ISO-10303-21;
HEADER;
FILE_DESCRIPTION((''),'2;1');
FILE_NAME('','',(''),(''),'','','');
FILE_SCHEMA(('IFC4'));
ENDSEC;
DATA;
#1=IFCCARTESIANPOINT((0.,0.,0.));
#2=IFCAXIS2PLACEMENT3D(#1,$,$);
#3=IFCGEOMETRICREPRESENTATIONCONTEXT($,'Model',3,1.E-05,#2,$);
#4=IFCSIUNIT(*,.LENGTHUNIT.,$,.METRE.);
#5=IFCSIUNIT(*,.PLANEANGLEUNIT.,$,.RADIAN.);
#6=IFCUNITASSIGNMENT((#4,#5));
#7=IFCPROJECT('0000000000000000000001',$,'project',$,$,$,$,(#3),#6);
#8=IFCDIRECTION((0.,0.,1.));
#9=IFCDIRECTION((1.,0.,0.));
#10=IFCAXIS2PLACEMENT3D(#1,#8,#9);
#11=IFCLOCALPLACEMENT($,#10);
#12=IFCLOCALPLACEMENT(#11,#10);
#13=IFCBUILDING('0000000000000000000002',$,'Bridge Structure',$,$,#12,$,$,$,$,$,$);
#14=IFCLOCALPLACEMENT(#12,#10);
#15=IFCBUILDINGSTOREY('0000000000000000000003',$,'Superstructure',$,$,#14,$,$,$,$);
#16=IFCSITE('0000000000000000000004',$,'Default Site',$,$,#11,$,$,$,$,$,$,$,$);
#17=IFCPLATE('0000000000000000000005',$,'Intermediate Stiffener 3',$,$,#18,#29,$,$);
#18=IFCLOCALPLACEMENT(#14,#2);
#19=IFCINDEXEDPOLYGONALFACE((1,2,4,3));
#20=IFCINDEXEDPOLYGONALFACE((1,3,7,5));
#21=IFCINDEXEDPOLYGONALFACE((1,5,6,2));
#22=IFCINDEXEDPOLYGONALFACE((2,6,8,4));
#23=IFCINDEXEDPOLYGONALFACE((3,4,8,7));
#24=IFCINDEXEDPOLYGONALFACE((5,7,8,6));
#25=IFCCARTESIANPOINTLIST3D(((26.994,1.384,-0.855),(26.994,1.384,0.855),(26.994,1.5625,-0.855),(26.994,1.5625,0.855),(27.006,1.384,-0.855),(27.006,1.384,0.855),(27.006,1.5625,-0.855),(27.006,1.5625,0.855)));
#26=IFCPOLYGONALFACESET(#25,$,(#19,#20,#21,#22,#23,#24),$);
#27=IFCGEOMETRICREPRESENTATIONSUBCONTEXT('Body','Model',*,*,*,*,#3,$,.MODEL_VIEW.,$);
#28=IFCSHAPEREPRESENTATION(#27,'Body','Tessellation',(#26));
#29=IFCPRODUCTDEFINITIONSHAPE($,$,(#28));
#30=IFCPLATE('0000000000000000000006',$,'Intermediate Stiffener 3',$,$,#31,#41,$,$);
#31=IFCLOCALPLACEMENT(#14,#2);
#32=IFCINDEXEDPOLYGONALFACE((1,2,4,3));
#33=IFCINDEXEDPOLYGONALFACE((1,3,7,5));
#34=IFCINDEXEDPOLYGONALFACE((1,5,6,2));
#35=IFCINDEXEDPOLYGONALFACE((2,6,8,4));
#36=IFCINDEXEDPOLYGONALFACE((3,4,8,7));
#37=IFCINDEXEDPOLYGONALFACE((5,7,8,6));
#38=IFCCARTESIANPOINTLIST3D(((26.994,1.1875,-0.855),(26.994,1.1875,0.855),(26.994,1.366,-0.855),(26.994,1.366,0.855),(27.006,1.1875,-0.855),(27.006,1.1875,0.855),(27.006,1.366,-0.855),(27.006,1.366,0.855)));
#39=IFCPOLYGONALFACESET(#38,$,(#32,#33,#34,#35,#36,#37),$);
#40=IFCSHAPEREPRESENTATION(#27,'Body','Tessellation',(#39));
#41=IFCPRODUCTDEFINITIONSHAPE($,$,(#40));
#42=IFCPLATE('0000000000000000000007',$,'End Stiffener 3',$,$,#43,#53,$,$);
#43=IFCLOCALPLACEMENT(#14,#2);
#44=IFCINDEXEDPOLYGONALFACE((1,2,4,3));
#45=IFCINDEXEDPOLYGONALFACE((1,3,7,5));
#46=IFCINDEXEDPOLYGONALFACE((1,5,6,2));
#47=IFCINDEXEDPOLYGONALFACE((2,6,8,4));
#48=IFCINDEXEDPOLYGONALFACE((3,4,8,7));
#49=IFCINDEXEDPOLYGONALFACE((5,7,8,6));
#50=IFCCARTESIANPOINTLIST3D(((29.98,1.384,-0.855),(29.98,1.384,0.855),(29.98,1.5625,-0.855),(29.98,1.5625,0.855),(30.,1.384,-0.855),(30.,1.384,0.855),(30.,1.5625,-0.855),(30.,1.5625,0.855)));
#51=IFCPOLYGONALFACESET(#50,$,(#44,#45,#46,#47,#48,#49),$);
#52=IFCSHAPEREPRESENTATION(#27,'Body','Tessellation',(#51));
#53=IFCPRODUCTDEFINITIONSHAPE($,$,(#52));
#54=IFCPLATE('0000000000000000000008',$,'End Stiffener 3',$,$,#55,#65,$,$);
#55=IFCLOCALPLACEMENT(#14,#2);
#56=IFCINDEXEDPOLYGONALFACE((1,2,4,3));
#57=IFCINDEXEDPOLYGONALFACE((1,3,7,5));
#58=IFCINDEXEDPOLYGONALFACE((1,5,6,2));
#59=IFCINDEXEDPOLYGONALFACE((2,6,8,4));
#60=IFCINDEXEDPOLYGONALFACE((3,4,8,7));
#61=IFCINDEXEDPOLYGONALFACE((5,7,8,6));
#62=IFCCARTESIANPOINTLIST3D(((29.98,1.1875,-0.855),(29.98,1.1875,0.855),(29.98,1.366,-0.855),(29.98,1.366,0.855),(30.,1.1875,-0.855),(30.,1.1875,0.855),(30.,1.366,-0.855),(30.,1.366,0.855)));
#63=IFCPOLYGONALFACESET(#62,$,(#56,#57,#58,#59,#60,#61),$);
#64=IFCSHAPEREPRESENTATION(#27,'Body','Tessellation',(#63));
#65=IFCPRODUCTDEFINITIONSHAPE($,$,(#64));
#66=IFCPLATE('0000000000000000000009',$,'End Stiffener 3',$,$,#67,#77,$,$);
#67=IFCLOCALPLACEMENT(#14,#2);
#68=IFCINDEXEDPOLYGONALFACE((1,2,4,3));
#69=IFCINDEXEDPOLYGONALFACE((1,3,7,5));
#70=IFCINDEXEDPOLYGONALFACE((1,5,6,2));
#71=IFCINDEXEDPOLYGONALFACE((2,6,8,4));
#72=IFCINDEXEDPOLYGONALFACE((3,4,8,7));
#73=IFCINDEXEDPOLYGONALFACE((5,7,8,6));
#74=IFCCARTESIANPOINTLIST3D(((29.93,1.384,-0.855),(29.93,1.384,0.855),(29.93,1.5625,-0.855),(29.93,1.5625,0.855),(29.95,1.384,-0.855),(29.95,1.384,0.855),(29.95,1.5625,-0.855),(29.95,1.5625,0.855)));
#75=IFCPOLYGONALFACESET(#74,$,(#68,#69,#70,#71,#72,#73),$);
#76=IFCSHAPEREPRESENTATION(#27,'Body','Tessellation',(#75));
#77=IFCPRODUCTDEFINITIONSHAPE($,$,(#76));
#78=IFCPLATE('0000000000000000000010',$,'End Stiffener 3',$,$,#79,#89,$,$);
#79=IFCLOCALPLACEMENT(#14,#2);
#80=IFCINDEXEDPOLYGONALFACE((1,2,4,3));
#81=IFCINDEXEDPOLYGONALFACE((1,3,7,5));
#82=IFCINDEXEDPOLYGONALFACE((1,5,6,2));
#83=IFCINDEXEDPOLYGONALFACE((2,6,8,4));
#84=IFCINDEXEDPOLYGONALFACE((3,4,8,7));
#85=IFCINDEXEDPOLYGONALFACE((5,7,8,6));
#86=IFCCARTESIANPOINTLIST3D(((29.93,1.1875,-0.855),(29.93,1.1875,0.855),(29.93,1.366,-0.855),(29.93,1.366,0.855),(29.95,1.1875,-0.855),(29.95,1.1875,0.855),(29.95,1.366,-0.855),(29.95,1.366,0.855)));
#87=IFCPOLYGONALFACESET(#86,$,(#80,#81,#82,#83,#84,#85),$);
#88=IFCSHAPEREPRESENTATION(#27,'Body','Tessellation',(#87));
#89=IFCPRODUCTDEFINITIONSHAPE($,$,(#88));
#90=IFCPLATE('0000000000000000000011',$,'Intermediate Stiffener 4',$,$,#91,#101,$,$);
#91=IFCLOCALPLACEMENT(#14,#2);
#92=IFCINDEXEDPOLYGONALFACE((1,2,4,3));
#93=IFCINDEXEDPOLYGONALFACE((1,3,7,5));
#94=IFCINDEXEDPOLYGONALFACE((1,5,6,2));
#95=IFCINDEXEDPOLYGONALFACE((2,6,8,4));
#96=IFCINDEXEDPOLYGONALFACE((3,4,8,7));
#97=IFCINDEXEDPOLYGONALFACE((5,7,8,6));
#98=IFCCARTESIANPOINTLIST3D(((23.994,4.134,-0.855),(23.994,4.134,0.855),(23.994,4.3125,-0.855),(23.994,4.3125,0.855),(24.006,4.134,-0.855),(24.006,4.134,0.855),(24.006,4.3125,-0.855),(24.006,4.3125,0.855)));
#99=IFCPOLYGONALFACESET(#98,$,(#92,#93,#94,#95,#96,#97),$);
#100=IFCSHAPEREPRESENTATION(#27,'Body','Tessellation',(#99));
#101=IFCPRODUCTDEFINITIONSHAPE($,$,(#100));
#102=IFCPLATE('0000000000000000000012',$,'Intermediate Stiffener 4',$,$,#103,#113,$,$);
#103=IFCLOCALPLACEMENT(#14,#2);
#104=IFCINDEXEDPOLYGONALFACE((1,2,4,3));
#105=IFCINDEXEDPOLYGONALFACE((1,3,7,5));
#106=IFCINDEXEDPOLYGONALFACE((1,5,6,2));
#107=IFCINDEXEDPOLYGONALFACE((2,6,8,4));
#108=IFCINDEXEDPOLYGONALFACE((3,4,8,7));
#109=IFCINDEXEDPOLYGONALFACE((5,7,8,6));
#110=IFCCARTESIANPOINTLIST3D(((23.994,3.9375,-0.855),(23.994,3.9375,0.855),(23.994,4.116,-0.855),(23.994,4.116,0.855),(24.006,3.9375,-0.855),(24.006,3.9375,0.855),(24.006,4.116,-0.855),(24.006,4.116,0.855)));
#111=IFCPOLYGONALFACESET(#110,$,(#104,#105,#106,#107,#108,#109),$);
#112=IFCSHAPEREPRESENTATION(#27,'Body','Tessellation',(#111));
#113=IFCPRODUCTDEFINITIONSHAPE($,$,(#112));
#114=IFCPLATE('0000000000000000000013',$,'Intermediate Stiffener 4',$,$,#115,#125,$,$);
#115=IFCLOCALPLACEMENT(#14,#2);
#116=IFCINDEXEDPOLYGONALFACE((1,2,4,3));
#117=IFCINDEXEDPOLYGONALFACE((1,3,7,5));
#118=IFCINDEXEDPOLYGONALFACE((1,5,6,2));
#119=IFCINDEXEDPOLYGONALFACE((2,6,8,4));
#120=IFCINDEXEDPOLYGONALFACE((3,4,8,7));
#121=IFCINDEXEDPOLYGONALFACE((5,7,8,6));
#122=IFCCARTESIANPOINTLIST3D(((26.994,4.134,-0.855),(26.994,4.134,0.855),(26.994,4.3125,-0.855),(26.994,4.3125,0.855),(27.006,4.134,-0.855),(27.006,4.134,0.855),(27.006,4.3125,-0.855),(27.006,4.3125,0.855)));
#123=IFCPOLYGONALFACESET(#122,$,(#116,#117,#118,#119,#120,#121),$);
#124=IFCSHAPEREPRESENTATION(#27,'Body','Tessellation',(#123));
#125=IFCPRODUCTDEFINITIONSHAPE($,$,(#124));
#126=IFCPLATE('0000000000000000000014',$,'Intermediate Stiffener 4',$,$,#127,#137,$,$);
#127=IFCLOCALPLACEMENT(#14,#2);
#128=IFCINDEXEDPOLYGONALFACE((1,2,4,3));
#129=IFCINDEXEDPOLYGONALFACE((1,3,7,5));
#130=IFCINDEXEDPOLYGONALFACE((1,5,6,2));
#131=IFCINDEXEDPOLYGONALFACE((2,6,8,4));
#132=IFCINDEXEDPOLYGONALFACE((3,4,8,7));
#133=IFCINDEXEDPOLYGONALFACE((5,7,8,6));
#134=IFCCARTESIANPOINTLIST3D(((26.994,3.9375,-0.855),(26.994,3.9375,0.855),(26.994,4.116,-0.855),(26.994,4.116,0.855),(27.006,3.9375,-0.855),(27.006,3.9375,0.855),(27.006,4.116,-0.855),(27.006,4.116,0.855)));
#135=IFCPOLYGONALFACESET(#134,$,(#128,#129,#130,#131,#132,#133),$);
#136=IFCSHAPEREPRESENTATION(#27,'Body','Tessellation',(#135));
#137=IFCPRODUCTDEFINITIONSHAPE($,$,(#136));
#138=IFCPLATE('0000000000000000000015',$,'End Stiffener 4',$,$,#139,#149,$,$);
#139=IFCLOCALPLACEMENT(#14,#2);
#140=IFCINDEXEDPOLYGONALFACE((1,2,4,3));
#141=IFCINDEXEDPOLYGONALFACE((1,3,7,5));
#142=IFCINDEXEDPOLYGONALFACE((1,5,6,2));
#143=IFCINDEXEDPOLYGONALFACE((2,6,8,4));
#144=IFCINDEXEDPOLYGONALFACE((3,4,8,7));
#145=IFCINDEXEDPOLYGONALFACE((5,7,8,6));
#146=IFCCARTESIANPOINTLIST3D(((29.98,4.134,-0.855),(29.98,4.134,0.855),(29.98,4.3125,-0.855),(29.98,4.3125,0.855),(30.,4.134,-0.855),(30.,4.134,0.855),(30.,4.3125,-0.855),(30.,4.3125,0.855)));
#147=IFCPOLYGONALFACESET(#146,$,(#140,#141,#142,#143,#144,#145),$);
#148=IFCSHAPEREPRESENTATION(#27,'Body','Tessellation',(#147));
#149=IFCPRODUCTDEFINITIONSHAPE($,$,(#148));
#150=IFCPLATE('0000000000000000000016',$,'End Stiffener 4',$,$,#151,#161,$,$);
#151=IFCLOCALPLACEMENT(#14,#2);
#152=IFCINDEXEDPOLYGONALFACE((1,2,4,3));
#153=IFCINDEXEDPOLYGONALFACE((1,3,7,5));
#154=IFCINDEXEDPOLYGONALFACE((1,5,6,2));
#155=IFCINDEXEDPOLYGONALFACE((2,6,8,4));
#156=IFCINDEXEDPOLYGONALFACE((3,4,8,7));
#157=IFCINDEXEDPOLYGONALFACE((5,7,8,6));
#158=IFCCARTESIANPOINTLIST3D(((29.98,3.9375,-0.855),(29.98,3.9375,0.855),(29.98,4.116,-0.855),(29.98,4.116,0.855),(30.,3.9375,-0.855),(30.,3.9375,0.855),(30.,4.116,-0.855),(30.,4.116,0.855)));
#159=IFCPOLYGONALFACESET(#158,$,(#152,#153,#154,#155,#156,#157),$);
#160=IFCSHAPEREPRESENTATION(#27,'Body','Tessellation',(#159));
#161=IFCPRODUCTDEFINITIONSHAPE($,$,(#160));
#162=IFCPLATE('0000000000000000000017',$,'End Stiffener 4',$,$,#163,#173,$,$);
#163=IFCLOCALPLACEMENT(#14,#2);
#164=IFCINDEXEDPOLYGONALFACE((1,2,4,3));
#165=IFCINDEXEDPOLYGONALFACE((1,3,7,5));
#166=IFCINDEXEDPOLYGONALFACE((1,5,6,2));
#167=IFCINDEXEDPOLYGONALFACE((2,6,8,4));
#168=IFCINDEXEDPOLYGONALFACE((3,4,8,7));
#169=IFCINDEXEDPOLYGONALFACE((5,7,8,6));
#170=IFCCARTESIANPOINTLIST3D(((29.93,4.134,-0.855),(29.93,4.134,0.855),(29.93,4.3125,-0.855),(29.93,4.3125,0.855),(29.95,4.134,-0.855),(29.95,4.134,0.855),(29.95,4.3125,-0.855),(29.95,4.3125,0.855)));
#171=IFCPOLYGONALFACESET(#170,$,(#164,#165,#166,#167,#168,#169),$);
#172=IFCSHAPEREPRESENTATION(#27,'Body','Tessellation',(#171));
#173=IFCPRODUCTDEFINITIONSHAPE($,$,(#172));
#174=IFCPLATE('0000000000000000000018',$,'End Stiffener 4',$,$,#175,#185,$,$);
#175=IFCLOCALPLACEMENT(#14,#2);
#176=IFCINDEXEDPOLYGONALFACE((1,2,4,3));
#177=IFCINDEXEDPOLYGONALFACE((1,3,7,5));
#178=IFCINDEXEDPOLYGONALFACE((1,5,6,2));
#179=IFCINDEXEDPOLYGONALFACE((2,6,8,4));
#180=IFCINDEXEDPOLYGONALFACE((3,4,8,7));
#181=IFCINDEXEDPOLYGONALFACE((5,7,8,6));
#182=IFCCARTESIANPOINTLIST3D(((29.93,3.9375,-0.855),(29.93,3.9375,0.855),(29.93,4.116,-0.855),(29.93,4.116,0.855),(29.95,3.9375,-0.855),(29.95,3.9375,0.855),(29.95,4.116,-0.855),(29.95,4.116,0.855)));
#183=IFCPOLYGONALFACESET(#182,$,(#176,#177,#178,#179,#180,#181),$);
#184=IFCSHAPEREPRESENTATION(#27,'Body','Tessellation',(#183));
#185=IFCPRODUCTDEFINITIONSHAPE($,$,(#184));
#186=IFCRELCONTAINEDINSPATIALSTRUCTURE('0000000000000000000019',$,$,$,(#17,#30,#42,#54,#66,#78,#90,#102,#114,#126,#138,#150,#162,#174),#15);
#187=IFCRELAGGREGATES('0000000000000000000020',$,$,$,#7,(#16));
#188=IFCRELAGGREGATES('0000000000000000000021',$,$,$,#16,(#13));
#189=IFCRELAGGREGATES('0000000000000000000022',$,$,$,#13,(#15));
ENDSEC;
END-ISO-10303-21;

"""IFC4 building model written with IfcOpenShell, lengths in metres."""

from ifc_helpers import new_model, si_unit, frame, origin, origin_with_axes, origin_2d_with_axis, place, context, subcontext, project, spatial, rectangle, extrude, element, save


model = new_model("IFC4")

# Units and contexts
model_context = context("Model", 3, precision=1e-05, world=origin())
body_context = subcontext(model_context, "Body", "Model", "MODEL_VIEW")
ifc_project = project(units=[si_unit("LENGTHUNIT", "METRE"), si_unit("PLANEANGLEUNIT", "RADIAN")], contexts=[model_context])

# Site, building, storey
site_placement = place(None, origin_with_axes())
site = spatial("IfcSite", under=ifc_project, at=site_placement, Name="Default Site")
building_placement = place(site_placement, origin_with_axes())
building = spatial("IfcBuilding", under=site, at=building_placement, Name="Bridge Structure")
storey_placement = place(building_placement, origin_with_axes())
storey = spatial("IfcBuildingStorey", under=building, at=storey_placement, Name="Superstructure")

# Plates
for number, where, z_axis, x_axis, name in (
    (1, (27.0, 1.4732, -0.855), (0.0, 0.0, 1.0), (1.0, 0.0, 0.0), "Intermediate Stiffener 3"),
    (2, (27.0, 1.2768, -0.855), (0.0, 0.0, 1.0), (1.0, 0.0, 0.0), "Intermediate Stiffener 3"),
):
    element("IfcPlate", number, at=place(storey_placement, frame(where, z_axis=z_axis, x_axis=x_axis)), inside=storey, Name=name, context=body_context, shape_type="SweptSolid", body=[
        extrude(rectangle(XDim=0.012, YDim=0.1785, at=origin_2d_with_axis()), origin_with_axes(), (0.0, 0.0, 1.0), 1.71),
    ])
for number, where, z_axis, x_axis, name in (
    (3, (29.99, 1.4732, -0.855), (0.0, 0.0, 1.0), (1.0, 0.0, 0.0), "End Stiffener 3"),
    (4, (29.99, 1.2768, -0.855), (0.0, 0.0, 1.0), (1.0, 0.0, 0.0), "End Stiffener 3"),
    (5, (29.94, 1.4732, -0.855), (0.0, 0.0, 1.0), (1.0, 0.0, 0.0), "End Stiffener 3"),
    (6, (29.94, 1.2768, -0.855), (0.0, 0.0, 1.0), (1.0, 0.0, 0.0), "End Stiffener 3"),
):
    element("IfcPlate", number, at=place(storey_placement, frame(where, z_axis=z_axis, x_axis=x_axis)), inside=storey, Name=name, context=body_context, shape_type="SweptSolid", body=[
        extrude(rectangle(XDim=0.02, YDim=0.1785, at=origin_2d_with_axis()), origin_with_axes(), (0.0, 0.0, 1.0), 1.71),
    ])
for number, where, z_axis, x_axis, name in (
    (7, (24.0, 4.2233, -0.855), (0.0, 0.0, 1.0), (1.0, 0.0, 0.0), "Intermediate Stiffener 4"),
    (8, (24.0, 4.0267, -0.855), (0.0, 0.0, 1.0), (1.0, 0.0, 0.0), "Intermediate Stiffener 4"),
    (9, (27.0, 4.2233, -0.855), (0.0, 0.0, 1.0), (1.0, 0.0, 0.0), "Intermediate Stiffener 4"),
    (10, (27.0, 4.0267, -0.855), (0.0, 0.0, 1.0), (1.0, 0.0, 0.0), "Intermediate Stiffener 4"),
):
    element("IfcPlate", number, at=place(storey_placement, frame(where, z_axis=z_axis, x_axis=x_axis)), inside=storey, Name=name, context=body_context, shape_type="SweptSolid", body=[
        extrude(rectangle(XDim=0.012, YDim=0.1785, at=origin_2d_with_axis()), origin_with_axes(), (0.0, 0.0, 1.0), 1.71),
    ])
for number, where, z_axis, x_axis, name in (
    (11, (29.99, 4.2233, -0.855), (0.0, 0.0, 1.0), (1.0, 0.0, 0.0), "End Stiffener 4"),
    (12, (29.99, 4.0267, -0.855), (0.0, 0.0, 1.0), (1.0, 0.0, 0.0), "End Stiffener 4"),
    (13, (29.94, 4.2233, -0.855), (0.0, 0.0, 1.0), (1.0, 0.0, 0.0), "End Stiffener 4"),
    (14, (29.94, 4.0267, -0.855), (0.0, 0.0, 1.0), (1.0, 0.0, 0.0), "End Stiffener 4"),
):
    element("IfcPlate", number, at=place(storey_placement, frame(where, z_axis=z_axis, x_axis=x_axis)), inside=storey, Name=name, context=body_context, shape_type="SweptSolid", body=[
        extrude(rectangle(XDim=0.02, YDim=0.1785, at=origin_2d_with_axis()), origin_with_axes(), (0.0, 0.0, 1.0), 1.71),
    ])

save(model, "model.ifc")
